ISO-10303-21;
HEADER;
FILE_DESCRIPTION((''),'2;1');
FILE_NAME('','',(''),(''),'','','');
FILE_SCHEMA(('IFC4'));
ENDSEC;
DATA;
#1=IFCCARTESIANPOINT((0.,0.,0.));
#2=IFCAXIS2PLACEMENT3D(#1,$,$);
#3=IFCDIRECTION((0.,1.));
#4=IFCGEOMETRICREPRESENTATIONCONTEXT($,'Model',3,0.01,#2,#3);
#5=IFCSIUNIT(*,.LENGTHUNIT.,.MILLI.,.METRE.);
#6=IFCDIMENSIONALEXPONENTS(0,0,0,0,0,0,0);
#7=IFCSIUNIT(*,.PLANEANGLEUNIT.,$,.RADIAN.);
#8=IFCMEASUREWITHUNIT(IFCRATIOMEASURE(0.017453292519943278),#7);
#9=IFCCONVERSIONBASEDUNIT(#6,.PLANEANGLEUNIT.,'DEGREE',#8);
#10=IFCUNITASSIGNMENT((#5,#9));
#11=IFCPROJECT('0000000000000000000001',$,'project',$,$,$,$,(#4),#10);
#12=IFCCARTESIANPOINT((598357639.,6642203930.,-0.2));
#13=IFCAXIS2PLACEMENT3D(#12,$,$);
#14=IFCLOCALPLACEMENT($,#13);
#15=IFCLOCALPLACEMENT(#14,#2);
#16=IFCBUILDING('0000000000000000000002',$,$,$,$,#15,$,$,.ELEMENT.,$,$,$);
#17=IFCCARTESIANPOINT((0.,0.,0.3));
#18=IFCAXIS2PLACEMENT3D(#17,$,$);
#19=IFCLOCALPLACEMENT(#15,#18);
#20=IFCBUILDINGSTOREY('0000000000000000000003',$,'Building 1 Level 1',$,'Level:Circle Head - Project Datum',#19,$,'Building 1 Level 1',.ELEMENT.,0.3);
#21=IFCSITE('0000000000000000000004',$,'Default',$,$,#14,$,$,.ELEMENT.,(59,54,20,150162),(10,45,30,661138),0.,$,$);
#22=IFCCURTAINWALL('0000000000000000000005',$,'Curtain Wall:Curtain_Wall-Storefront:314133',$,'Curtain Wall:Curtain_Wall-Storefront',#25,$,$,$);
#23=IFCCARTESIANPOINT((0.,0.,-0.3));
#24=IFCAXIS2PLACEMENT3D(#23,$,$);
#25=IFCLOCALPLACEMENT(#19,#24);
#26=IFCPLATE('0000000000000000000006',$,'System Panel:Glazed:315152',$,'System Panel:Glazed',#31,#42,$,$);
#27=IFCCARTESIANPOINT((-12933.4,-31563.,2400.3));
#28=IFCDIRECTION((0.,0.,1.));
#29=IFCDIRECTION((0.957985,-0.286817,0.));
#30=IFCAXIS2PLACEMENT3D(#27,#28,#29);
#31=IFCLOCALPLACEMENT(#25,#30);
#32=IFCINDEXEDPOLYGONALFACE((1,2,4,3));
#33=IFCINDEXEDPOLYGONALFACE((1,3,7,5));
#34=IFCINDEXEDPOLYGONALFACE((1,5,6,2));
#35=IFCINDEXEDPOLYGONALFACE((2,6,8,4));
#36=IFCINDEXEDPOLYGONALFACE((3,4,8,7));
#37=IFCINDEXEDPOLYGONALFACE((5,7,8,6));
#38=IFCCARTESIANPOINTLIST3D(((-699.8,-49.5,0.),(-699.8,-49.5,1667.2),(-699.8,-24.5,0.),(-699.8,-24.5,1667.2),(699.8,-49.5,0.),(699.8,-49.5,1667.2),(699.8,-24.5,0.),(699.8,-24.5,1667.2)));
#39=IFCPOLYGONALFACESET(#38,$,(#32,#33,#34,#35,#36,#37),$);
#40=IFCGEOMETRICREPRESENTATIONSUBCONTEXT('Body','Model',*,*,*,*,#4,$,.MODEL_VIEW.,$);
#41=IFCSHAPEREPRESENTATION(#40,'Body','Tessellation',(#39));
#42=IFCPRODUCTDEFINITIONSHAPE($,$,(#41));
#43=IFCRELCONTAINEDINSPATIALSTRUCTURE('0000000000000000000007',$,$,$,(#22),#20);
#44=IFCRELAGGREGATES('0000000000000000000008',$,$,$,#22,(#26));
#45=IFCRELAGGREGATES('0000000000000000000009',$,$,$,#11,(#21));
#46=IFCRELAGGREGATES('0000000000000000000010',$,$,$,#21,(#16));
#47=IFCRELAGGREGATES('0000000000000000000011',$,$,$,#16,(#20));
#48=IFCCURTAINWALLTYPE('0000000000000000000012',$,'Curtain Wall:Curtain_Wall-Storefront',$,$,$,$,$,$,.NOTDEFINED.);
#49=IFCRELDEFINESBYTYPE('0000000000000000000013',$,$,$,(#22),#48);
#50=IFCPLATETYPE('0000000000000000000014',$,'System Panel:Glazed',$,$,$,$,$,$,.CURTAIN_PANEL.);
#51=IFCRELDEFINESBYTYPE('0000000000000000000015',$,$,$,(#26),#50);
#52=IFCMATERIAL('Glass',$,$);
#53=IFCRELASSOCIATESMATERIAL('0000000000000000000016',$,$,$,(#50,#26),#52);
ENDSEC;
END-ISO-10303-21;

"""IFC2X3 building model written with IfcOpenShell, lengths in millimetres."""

from ifc_helpers import new_model, entity, si_unit, converted_unit, direction, frame, frame_2d, origin, place, context, subcontext, project, spatial, rectangle, extrude, source, transform, mapped, material, type_object, type_shapes, element, aggregate, save


model = new_model("IFC2X3")

# Units and contexts
model_context = context("Model", 3, precision=0.01, world=origin(), true_north=direction((0.0, 1.0)))
body_context = subcontext(model_context, "Body", "Model", "MODEL_VIEW")
ifc_project = project(units=[si_unit("LENGTHUNIT", "METRE", prefix="MILLI"), converted_unit("PLANEANGLEUNIT", "DEGREE", entity("IfcRatioMeasure", 0.017453292519943278), si_unit("PLANEANGLEUNIT", "RADIAN"), dimensions=[0, 0, 0, 0, 0, 0, 0])], contexts=[model_context])

# Site, building, storey
site_placement = place(None, frame((598357639.0, 6642203930.0, -0.2)))
site = spatial("IfcSite", under=ifc_project, at=site_placement, Name="Default", CompositionType="ELEMENT", RefLatitude=(59, 54, 20, 150162), RefLongitude=(10, 45, 30, 661138), RefElevation=0.0)
building_placement = place(site_placement, origin())
building = spatial("IfcBuilding", under=site, at=building_placement, CompositionType="ELEMENT")
storey_placement = place(building_placement, frame((0.0, 0.0, 0.3)))
storey = spatial("IfcBuildingStorey", under=building, at=storey_placement, Name="Building 1 Level 1", ObjectType="Level:Circle Head - Project Datum", LongName="Building 1 Level 1", CompositionType="ELEMENT", Elevation=0.3)

# Shared definitions
curtain_wall_type = type_object("IfcCurtainWallType", Name="Curtain Wall:Curtain_Wall-Storefront", PredefinedType="NOTDEFINED")
ifc_material = material(Name="Glass")

# Curtain wall, plate
curtain_wall_1_placement = place(storey_placement, frame((0.0, 0.0, -0.3)))
curtain_wall_1 = element("IfcCurtainWall", 1, at=curtain_wall_1_placement, inside=storey, type_object=curtain_wall_type, Name="Curtain Wall:Curtain_Wall-Storefront:314133", ObjectType="Curtain Wall:Curtain_Wall-Storefront")
plate_type_1 = type_object("IfcPlateType", Name="System Panel:Glazed", PredefinedType="CURTAIN_PANEL", material=ifc_material)
shared_shape_1 = source(origin(), body_context, "Body", "SweptSolid", [
    extrude(rectangle(XDim=25.0, YDim=1399.6, at=frame_2d((0.0, 0.0), x_axis=(1.0, 0.0))), frame((0.0, -37.0, 0.0), z_axis=(0.0, 0.0, 1.0), x_axis=(0.0, 1.0, 0.0)), (0.0, 0.0, 1.0), 1667.2),
])
type_shapes(plate_type_1, [shared_shape_1])
plate_1_placement = place(curtain_wall_1_placement, frame((-12933.4, -31563.0, 2400.3), z_axis=(0.0, 0.0, 1.0), x_axis=(0.957985, -0.286817, 0.0)))
plate_1 = element("IfcPlate", 2, at=plate_1_placement, type_object=plate_type_1, material=ifc_material, Name="System Panel:Glazed:315152", ObjectType="System Panel:Glazed", context=body_context, shape_type="MappedRepresentation", body=[
    mapped(shared_shape_1, transform((0.0, 0.0, 0.0), scale=1.0)),
])
aggregate(curtain_wall_1, [plate_1])

save(model, "model.ifc")
